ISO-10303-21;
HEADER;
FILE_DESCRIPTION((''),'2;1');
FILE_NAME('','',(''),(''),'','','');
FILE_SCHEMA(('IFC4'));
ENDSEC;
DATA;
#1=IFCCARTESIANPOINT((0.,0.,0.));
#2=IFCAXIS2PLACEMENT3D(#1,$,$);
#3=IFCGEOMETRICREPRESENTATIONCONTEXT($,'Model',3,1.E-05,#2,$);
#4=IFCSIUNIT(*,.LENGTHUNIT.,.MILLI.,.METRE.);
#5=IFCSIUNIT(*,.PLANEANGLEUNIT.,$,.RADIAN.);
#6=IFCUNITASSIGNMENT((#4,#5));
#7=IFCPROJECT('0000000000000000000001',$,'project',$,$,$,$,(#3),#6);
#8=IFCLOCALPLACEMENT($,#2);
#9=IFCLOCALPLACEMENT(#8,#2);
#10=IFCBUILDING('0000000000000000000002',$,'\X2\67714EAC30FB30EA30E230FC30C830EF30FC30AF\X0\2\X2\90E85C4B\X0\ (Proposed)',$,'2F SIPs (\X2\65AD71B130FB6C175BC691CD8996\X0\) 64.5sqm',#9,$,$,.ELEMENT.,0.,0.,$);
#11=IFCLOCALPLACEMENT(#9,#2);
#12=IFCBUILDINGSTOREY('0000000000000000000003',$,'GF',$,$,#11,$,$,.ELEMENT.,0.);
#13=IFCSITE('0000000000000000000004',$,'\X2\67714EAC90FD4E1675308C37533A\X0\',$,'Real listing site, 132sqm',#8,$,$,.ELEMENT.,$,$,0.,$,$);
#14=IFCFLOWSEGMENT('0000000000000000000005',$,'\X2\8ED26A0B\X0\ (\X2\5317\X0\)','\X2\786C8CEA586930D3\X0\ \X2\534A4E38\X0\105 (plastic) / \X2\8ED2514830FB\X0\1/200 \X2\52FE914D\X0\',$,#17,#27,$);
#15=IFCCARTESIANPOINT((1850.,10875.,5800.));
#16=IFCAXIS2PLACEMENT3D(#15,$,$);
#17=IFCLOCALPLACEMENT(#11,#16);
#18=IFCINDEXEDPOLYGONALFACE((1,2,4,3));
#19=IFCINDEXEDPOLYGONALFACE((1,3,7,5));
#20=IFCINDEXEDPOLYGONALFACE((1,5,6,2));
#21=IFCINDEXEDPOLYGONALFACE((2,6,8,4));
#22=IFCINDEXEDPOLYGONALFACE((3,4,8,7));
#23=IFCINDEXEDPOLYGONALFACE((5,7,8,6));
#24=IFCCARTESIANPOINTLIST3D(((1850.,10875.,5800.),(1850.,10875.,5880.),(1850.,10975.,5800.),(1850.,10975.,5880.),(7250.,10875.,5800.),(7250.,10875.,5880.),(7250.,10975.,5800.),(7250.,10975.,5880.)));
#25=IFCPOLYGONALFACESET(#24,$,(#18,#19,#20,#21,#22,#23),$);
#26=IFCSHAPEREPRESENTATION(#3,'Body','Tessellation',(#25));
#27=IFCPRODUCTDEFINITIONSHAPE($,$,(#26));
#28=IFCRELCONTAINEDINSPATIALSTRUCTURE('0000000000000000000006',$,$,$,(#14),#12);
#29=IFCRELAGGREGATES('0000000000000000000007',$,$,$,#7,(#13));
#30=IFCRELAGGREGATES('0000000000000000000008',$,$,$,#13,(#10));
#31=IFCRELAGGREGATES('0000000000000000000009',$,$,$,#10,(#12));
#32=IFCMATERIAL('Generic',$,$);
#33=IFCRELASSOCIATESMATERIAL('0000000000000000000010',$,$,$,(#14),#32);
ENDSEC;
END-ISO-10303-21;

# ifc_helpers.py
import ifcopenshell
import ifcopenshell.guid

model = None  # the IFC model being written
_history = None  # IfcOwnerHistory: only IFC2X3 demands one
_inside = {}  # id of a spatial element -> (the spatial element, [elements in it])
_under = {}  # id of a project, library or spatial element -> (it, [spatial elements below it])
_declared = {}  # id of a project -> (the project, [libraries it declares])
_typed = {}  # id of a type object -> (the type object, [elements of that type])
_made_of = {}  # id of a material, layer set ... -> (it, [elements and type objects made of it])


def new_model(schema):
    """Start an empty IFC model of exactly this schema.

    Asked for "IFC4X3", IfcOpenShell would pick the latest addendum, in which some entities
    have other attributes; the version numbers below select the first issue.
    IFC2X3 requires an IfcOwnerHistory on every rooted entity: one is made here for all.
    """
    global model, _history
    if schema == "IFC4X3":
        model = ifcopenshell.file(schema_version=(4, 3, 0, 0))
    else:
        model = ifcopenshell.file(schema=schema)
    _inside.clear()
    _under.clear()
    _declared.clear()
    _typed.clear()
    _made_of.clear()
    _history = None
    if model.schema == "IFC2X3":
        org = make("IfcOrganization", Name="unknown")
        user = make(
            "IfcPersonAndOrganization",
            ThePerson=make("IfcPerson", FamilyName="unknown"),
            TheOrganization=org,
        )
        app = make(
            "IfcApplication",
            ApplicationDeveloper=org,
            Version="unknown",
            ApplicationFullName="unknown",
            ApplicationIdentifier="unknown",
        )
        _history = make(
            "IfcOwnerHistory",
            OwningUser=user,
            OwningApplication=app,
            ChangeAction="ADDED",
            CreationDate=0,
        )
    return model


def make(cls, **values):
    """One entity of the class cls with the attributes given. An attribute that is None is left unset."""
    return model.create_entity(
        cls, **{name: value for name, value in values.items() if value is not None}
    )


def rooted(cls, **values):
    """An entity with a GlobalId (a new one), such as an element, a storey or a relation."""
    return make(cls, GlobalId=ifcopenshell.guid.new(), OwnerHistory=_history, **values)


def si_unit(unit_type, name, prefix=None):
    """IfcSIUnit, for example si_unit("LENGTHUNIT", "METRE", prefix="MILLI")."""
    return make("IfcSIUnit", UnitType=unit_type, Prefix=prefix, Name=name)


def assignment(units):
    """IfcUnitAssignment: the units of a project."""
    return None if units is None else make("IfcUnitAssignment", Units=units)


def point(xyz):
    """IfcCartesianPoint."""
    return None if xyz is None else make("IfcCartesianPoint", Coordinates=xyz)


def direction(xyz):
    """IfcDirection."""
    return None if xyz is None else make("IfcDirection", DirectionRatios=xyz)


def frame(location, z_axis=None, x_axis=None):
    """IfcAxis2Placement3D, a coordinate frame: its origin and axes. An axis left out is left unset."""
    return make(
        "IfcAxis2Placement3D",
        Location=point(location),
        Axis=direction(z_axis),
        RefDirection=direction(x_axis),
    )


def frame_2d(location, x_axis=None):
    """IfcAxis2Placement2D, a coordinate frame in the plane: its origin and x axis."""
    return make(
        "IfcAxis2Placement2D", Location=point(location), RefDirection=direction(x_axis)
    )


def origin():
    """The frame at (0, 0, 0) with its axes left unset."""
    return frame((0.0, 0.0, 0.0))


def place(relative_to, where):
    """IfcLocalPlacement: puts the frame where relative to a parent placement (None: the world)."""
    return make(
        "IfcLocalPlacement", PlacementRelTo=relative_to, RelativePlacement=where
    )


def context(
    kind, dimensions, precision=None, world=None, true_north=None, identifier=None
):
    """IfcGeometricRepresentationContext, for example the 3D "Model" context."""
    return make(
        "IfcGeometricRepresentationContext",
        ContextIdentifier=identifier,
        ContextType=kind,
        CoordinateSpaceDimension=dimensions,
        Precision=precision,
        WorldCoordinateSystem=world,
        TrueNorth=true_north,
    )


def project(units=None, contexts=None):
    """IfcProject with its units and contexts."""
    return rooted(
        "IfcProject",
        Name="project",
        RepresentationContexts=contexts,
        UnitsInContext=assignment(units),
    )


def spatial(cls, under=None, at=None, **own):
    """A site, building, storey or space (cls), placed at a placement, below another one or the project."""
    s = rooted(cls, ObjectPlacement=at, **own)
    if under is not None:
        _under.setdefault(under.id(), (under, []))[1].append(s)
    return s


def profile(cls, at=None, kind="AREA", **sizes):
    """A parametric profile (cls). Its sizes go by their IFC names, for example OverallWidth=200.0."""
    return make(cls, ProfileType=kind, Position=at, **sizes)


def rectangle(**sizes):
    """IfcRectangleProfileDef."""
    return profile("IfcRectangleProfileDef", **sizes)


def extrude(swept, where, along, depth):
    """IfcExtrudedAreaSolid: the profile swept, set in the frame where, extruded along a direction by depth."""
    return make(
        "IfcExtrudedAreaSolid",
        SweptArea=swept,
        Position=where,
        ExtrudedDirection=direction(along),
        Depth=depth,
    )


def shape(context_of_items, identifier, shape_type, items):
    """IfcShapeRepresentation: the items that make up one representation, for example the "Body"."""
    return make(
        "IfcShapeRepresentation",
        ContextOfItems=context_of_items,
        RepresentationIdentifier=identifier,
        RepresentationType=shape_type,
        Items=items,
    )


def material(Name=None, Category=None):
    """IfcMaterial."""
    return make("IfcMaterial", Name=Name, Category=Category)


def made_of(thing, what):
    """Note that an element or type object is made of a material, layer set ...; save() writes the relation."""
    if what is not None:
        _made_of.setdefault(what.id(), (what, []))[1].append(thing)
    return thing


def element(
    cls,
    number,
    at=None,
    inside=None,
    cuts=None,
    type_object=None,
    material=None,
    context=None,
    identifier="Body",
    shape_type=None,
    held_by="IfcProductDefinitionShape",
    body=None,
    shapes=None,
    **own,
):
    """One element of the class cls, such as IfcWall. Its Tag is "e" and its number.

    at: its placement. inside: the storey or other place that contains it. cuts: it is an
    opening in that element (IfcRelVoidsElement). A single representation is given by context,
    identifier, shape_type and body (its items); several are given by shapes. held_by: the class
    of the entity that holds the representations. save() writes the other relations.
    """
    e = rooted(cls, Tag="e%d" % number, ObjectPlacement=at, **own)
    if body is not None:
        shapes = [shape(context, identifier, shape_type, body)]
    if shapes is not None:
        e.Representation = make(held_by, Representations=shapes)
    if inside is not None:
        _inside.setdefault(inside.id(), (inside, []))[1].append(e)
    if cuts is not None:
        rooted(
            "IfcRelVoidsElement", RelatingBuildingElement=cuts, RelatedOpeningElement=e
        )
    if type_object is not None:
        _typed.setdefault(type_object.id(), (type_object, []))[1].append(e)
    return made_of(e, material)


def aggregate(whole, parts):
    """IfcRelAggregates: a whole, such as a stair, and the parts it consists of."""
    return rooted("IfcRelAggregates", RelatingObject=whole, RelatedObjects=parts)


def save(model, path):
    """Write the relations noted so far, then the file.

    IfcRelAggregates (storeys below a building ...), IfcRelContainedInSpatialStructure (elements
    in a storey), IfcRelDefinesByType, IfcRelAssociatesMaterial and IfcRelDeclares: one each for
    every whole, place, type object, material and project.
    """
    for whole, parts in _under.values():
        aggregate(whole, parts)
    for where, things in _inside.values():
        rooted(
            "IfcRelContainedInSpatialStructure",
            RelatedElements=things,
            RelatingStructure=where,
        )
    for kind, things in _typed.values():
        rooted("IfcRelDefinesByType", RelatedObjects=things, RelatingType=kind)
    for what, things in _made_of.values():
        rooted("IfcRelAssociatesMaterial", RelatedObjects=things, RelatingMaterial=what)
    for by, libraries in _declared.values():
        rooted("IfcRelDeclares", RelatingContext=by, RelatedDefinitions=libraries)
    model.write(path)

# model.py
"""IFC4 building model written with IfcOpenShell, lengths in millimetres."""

from ifc_helpers import new_model, si_unit, frame, frame_2d, origin, place, context, project, spatial, rectangle, extrude, material, element, save


model = new_model("IFC4")

# Units and contexts
model_context = context("Model", 3, precision=1e-05, world=origin())
ifc_project = project(units=[si_unit("LENGTHUNIT", "METRE", prefix="MILLI"), si_unit("PLANEANGLEUNIT", "RADIAN")], contexts=[model_context])

# Site, building, storey
site_placement = place(None, origin())
site = spatial("IfcSite", under=ifc_project, at=site_placement, Name="東京都世田谷区", ObjectType="Real listing site, 132sqm", CompositionType="ELEMENT", RefElevation=0.0)
building_placement = place(site_placement, origin())
building = spatial("IfcBuilding", under=site, at=building_placement, Name="東京・リモートワーク2部屋 (Proposed)", ObjectType="2F SIPs (断熱・気密重視) 64.5sqm", CompositionType="ELEMENT", ElevationOfRefHeight=0.0, ElevationOfTerrain=0.0)
storey_placement = place(building_placement, origin())
storey = spatial("IfcBuildingStorey", under=building, at=storey_placement, Name="GF", CompositionType="ELEMENT", Elevation=0.0)

# Shared definitions
ifc_material_1 = material(Name="Generic")

# Flow segment
flow_segment_placement = place(storey_placement, frame((1850.0, 10875.0, 5800.0)))
element("IfcFlowSegment", 1, at=flow_segment_placement, inside=storey, material=ifc_material_1, Name="軒樋 (北)", Description="硬質塩ビ 半丸105 (plastic) / 軒先・1/200 勾配", context=model_context, shape_type="SweptSolid", body=[
    extrude(rectangle(XDim=5400.0, YDim=100.0, at=frame_2d((2700.0, 50.0))), frame((1850.0, 10875.0, 5800.0)), (0.0, 0.0, 1.0), 80.0),
])

save(model, "model.ifc")
